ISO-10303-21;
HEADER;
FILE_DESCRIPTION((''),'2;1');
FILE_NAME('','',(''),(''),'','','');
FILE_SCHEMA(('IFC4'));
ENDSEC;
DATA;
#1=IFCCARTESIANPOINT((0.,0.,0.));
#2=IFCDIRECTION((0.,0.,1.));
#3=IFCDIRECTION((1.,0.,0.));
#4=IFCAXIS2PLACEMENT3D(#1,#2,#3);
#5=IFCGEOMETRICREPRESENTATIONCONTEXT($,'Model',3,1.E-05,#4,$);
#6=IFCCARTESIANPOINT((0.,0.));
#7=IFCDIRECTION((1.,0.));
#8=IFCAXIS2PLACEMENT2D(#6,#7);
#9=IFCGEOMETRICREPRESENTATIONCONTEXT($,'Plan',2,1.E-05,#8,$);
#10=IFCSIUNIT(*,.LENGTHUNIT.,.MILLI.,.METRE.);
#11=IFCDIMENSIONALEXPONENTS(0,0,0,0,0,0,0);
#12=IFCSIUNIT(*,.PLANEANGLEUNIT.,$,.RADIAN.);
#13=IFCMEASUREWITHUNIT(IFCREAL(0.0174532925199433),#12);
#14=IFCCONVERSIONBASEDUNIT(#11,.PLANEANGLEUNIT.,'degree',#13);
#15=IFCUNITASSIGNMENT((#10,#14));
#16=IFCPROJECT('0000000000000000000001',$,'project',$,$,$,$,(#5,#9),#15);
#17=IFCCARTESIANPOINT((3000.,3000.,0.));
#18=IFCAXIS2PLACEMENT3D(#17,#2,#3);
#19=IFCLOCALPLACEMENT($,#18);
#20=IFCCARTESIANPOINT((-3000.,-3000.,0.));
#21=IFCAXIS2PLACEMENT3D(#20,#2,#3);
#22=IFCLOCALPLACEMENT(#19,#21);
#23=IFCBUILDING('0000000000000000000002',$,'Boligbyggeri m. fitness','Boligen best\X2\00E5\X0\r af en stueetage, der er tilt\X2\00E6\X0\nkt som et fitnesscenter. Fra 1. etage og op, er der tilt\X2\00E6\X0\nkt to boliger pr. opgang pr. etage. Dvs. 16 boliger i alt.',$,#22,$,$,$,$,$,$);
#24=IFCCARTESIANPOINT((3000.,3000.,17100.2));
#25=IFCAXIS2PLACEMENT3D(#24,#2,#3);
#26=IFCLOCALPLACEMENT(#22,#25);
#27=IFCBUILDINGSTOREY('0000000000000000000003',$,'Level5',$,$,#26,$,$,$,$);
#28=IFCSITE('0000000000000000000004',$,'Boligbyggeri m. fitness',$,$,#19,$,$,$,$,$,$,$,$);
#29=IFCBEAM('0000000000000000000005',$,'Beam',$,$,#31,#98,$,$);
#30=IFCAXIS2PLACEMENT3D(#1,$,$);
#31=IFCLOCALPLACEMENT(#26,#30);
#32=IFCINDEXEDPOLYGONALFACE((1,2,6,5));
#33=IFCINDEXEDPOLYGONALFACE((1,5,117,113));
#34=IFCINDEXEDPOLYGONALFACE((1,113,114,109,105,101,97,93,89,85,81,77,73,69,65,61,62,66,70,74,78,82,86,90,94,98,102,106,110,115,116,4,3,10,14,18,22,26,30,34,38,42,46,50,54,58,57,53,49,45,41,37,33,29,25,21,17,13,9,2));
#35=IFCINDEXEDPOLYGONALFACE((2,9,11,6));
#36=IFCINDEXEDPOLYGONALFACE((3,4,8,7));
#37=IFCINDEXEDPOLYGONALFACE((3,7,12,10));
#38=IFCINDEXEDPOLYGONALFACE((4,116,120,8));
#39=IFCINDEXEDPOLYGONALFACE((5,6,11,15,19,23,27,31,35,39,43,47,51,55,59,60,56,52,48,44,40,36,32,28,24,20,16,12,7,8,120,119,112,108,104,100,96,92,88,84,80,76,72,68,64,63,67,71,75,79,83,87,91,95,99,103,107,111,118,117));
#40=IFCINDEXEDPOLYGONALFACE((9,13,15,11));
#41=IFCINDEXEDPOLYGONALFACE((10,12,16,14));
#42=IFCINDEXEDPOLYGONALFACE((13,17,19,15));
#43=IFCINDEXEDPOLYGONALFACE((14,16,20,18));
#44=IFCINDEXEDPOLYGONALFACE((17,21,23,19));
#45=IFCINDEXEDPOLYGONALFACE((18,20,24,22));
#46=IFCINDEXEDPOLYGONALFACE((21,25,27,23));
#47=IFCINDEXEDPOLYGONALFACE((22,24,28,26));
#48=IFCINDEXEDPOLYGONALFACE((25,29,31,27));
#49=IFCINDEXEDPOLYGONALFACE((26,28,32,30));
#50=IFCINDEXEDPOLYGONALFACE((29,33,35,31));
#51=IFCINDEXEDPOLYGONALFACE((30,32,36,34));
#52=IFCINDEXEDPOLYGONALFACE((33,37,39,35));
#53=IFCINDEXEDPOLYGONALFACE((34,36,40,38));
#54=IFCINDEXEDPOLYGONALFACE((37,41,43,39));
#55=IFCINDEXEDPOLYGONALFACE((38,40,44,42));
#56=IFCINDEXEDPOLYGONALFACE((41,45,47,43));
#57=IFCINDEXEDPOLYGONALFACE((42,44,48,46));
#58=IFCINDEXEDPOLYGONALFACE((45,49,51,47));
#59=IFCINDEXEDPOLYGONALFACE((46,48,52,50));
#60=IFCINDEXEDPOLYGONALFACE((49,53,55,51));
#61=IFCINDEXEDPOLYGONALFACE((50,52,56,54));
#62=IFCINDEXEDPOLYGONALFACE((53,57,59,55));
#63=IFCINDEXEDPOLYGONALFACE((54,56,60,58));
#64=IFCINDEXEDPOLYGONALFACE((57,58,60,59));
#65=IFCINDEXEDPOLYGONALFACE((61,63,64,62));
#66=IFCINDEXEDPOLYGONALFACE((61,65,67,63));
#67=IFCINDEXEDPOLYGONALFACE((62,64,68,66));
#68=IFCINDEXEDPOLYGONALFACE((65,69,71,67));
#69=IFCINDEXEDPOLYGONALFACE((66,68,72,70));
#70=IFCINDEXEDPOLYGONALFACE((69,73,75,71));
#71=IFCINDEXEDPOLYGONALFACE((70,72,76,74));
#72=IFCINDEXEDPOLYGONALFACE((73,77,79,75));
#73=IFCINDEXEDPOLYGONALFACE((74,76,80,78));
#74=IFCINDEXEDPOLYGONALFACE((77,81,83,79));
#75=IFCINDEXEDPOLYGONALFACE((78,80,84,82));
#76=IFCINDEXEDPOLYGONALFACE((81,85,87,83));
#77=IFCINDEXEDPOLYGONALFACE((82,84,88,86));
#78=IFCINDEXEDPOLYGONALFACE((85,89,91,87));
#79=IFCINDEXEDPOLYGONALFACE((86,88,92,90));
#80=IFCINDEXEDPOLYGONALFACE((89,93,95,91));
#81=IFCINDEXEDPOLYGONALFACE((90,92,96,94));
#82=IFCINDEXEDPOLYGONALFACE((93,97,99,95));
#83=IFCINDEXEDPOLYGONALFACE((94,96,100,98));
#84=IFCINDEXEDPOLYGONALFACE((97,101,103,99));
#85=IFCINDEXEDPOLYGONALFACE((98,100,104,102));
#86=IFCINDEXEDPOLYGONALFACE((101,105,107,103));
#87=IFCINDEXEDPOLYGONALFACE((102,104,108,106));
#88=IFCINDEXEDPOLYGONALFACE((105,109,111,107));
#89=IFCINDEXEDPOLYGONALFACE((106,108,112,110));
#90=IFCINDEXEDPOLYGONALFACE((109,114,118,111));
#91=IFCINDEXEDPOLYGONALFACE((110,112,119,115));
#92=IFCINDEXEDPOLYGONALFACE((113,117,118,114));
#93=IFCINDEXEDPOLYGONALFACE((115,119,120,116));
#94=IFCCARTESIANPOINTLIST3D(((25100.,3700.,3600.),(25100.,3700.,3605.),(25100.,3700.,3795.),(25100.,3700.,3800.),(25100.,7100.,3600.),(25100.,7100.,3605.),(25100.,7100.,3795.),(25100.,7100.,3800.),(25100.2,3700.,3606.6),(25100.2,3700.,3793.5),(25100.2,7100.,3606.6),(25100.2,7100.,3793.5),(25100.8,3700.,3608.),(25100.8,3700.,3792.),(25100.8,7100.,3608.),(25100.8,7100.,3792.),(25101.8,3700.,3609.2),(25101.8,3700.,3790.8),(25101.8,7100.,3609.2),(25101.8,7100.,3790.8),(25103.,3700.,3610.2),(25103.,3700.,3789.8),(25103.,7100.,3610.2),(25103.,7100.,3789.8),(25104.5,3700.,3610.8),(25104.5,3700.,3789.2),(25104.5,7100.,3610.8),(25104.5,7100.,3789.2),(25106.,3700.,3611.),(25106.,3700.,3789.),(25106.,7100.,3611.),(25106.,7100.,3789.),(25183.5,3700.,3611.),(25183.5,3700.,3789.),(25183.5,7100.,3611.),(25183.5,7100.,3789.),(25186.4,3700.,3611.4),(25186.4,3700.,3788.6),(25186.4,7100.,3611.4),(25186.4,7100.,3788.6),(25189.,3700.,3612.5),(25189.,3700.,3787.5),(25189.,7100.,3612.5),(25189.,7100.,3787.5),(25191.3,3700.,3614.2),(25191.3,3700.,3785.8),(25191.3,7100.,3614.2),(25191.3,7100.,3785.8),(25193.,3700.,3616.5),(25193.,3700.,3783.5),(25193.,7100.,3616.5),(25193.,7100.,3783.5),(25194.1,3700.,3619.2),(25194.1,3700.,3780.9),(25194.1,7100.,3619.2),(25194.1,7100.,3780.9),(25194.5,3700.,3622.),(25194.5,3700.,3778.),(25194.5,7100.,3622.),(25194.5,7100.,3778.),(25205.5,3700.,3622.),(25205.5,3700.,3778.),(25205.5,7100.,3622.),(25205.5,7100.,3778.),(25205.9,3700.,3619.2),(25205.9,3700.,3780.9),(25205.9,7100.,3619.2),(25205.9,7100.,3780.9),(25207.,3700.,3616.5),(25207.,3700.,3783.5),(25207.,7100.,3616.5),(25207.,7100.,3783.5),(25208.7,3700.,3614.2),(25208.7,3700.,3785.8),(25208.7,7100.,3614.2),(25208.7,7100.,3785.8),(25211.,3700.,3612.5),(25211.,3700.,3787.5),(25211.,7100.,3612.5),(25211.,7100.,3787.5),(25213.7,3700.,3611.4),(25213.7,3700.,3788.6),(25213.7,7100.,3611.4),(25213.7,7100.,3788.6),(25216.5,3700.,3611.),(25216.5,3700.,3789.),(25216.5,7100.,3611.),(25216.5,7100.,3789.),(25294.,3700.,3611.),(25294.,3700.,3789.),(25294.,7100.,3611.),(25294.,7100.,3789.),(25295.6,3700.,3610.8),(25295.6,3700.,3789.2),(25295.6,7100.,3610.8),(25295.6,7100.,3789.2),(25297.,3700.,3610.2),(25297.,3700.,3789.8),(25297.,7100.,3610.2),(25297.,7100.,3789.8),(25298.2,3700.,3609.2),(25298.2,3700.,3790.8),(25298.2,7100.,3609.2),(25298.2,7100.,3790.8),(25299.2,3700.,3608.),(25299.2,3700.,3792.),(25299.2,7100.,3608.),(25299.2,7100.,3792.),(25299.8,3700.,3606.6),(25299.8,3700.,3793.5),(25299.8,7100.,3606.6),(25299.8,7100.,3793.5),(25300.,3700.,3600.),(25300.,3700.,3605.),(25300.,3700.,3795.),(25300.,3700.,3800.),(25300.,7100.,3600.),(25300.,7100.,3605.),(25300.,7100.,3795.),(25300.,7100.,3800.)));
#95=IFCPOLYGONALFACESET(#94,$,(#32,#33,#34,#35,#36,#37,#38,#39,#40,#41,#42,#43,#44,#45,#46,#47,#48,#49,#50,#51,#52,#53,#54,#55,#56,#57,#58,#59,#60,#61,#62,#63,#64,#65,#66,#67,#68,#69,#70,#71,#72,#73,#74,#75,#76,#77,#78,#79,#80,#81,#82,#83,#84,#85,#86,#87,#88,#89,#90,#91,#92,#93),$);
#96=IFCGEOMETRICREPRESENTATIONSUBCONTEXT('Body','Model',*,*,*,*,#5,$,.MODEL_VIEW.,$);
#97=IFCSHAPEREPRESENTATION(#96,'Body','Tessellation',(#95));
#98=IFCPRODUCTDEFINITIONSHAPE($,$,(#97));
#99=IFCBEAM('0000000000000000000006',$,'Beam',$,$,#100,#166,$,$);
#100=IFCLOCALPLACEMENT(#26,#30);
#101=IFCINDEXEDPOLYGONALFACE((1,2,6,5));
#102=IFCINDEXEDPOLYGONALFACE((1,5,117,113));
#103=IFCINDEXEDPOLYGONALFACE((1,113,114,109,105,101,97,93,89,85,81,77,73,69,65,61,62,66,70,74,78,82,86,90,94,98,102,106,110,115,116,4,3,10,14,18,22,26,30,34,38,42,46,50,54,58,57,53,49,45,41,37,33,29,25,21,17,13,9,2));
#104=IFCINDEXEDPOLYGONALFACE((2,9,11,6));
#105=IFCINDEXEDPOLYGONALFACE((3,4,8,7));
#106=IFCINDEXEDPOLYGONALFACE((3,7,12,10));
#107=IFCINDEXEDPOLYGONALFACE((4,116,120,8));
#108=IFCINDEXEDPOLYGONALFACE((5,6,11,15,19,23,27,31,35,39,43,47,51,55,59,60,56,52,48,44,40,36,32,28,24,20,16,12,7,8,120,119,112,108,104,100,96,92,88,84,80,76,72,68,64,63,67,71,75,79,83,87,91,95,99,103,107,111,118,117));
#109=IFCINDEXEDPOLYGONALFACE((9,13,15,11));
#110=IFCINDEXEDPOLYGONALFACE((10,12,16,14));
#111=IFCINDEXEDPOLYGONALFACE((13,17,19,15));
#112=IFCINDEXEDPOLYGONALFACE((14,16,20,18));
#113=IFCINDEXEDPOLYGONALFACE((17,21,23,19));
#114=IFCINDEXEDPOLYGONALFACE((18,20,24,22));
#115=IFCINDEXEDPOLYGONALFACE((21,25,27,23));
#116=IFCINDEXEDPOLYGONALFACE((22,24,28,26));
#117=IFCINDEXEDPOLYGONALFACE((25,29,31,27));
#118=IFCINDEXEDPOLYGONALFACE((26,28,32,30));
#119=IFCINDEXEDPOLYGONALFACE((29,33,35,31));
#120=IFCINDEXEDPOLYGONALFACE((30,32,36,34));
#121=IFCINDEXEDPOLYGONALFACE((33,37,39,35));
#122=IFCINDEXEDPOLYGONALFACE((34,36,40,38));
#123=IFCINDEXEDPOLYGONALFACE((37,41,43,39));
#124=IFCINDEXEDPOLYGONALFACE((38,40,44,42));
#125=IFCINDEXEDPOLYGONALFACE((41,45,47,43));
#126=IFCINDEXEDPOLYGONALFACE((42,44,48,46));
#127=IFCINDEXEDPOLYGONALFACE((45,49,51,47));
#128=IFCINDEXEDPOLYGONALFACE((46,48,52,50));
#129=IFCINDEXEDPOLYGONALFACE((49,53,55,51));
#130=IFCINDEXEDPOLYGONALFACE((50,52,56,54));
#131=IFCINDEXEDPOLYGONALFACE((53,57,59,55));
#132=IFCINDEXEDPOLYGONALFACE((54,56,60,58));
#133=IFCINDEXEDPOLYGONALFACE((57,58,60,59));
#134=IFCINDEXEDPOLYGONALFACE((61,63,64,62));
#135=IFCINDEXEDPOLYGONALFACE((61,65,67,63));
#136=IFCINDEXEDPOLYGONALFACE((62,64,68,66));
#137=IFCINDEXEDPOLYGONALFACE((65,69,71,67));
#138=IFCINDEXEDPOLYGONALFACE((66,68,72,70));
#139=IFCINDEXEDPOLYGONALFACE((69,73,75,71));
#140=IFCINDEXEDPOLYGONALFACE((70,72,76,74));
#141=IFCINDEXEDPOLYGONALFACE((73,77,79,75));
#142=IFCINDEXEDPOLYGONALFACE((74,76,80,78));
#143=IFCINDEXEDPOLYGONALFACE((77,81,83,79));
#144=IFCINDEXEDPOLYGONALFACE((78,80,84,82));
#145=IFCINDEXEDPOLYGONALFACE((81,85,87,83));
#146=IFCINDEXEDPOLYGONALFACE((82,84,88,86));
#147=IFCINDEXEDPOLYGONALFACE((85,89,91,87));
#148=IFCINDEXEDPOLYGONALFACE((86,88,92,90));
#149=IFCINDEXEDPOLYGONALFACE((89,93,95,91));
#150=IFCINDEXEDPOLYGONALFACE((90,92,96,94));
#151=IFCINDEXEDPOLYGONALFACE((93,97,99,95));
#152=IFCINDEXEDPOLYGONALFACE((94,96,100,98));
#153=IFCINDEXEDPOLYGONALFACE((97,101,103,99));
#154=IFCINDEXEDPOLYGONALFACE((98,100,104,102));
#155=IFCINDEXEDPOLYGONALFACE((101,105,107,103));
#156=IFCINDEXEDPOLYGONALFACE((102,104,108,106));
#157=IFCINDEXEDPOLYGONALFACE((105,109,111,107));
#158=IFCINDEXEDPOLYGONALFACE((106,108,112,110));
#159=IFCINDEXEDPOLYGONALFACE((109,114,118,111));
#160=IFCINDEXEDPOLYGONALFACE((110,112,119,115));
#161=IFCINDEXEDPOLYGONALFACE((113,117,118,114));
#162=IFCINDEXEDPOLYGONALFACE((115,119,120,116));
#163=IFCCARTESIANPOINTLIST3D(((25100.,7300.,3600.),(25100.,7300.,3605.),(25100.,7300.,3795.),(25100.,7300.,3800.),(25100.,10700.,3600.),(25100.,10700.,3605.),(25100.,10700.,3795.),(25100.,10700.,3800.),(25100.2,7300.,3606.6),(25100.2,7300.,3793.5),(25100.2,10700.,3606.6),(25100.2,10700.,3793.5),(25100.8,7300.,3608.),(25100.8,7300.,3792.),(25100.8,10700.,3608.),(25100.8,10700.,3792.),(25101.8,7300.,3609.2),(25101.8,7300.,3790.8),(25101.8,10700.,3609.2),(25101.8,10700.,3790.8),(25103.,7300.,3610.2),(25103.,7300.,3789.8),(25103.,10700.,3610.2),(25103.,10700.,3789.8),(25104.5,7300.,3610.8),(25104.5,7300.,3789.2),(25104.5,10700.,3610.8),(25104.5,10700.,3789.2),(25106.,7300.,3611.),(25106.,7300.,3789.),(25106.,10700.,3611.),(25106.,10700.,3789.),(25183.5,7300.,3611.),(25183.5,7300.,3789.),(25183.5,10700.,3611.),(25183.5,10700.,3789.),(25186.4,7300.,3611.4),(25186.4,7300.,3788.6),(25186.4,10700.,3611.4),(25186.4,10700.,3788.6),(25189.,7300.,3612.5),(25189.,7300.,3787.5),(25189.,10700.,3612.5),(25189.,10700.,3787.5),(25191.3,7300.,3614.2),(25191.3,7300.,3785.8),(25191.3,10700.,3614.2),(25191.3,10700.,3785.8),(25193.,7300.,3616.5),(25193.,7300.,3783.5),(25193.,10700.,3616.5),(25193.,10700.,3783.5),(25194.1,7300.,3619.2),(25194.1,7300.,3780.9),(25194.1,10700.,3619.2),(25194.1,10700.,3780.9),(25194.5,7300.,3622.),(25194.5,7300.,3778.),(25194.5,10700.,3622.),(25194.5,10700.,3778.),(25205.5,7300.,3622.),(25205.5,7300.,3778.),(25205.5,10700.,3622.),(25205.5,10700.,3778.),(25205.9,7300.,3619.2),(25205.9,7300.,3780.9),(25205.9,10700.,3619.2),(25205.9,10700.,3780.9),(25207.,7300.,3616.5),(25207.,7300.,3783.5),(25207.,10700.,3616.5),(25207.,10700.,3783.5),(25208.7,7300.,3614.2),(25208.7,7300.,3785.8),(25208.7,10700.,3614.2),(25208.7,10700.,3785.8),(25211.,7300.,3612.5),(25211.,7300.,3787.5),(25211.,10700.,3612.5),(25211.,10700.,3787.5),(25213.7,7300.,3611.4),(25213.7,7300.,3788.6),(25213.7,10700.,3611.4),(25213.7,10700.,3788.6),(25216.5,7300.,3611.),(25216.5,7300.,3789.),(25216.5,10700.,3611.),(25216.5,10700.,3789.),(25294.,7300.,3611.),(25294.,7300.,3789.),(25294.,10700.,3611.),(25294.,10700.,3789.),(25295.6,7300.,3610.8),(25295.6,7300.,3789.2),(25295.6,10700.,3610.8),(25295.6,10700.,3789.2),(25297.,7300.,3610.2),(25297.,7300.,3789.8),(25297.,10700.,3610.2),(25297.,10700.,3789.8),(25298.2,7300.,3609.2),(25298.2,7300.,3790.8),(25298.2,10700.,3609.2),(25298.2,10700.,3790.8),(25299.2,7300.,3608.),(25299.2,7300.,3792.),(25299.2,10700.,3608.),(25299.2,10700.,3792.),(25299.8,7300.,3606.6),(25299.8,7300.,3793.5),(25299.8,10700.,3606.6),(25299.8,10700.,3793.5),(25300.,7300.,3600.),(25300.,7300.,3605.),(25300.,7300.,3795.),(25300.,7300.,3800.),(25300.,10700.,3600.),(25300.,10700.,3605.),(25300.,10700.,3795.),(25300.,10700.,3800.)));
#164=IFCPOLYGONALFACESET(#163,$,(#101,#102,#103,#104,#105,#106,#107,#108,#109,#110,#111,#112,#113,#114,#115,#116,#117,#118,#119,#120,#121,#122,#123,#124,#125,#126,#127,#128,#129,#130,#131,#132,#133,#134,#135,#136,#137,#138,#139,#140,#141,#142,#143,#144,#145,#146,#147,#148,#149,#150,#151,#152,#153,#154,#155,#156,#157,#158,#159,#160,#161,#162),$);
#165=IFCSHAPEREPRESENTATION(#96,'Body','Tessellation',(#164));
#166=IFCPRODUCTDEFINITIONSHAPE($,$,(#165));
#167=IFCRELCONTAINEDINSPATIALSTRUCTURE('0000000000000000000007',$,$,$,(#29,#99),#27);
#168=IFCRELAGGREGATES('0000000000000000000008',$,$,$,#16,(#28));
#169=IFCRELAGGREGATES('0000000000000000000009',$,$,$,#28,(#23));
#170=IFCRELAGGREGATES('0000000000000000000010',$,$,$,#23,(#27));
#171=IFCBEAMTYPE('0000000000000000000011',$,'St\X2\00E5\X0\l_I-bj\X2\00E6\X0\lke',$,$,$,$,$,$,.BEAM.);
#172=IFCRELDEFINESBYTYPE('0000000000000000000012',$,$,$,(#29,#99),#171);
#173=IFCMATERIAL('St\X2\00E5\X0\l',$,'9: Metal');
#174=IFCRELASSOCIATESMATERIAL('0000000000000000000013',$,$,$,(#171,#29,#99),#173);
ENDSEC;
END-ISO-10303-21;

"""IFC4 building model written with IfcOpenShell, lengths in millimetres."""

from ifc_helpers import new_model, entity, si_unit, converted_unit, frame, origin_with_axes, origin_2d_with_axis, place, context, subcontext, project, spatial, i_section, extrude, material, material_profile, profile_set, profile_usage, type_object, element, save


model = new_model("IFC4")

# Units and contexts
model_context = context("Model", 3, precision=1e-05, world=origin_with_axes())
plan_context = context("Plan", 2, precision=1e-05, world=origin_2d_with_axis())
body_context = subcontext(model_context, "Body", "Model", "MODEL_VIEW")
ifc_project = project(units=[si_unit("LENGTHUNIT", "METRE", prefix="MILLI"), converted_unit("PLANEANGLEUNIT", "degree", entity("IfcReal", 0.0174532925199433), si_unit("PLANEANGLEUNIT", "RADIAN"), dimensions=[0, 0, 0, 0, 0, 0, 0])], contexts=[model_context, plan_context])

# Site, building, storey
site_placement = place(None, frame((3000.0, 3000.0, 0.0), z_axis=(0.0, 0.0, 1.0), x_axis=(1.0, 0.0, 0.0)))
site = spatial("IfcSite", under=ifc_project, at=site_placement, Name="Boligbyggeri m. fitness")
building_placement = place(site_placement, frame((-3000.0, -3000.0, 0.0), z_axis=(0.0, 0.0, 1.0), x_axis=(1.0, 0.0, 0.0)))
building = spatial("IfcBuilding", under=site, at=building_placement, Name="Boligbyggeri m. fitness", Description="Boligen består af en stueetage, der er tiltænkt som et fitnesscenter. Fra 1. etage og op, er der tiltænkt to boliger pr. opgang pr. etage. Dvs. 16 boliger i alt.")
storey_placement = place(building_placement, frame((3000.0, 3000.0, 17100.2), z_axis=(0.0, 0.0, 1.0), x_axis=(1.0, 0.0, 0.0)))
storey = spatial("IfcBuildingStorey", under=building, at=storey_placement, Name="Level5")

# Beams
ifc_material_1 = material(Name="Stål", Category="9: Metal")
ifc_material_profile_1 = material_profile(ifc_material_1, i_section(OverallWidth=200.0, OverallDepth=200.0, WebThickness=11.0, FlangeThickness=11.0, FilletRadius=11.0, FlangeEdgeRadius=6.0), Name="Stål", Category="9: Metal")
ifc_profile_set_1 = profile_set([ifc_material_profile_1], Name="NY_I-Profil")
beam_type = type_object("IfcBeamType", Name="Stål_I-bjælke", PredefinedType="BEAM", material=ifc_profile_set_1)
ifc_profile_usage_1 = profile_usage(ifc_profile_set_1, cardinal=9)
beam_1_placement = place(storey_placement, frame((25300.0, 3700.0, 3800.0), z_axis=(0.0, 1.0, 0.0), x_axis=(-1.0, 0.0, 0.0)))
element("IfcBeam", 1, at=beam_1_placement, inside=storey, type_object=beam_type, material=ifc_profile_usage_1, Name="Beam", context=body_context, shape_type="SweptSolid", body=[
    extrude(i_section(OverallWidth=200.0, OverallDepth=200.0, WebThickness=11.0, FlangeThickness=11.0, FilletRadius=11.0, FlangeEdgeRadius=6.0), frame((100.0, -100.0, 0.0), z_axis=(0.0, 0.0, 1.0), x_axis=(1.0, 0.0, 0.0)), (0.0, 0.0, 1.0), 3400.0),
])
ifc_profile_usage_2 = profile_usage(ifc_profile_set_1, cardinal=9)
beam_2_placement = place(storey_placement, frame((25300.0, 7300.0, 3800.0), z_axis=(0.0, 1.0, 0.0), x_axis=(-1.0, 0.0, 0.0)))
element("IfcBeam", 2, at=beam_2_placement, inside=storey, type_object=beam_type, material=ifc_profile_usage_2, Name="Beam", context=body_context, shape_type="SweptSolid", body=[
    extrude(i_section(OverallWidth=200.0, OverallDepth=200.0, WebThickness=11.0, FlangeThickness=11.0, FilletRadius=11.0, FlangeEdgeRadius=6.0), frame((100.0, -100.0, 0.0), z_axis=(0.0, 0.0, 1.0), x_axis=(1.0, 0.0, 0.0)), (0.0, 0.0, 1.0), 3400.0),
])

save(model, "model.ifc")
